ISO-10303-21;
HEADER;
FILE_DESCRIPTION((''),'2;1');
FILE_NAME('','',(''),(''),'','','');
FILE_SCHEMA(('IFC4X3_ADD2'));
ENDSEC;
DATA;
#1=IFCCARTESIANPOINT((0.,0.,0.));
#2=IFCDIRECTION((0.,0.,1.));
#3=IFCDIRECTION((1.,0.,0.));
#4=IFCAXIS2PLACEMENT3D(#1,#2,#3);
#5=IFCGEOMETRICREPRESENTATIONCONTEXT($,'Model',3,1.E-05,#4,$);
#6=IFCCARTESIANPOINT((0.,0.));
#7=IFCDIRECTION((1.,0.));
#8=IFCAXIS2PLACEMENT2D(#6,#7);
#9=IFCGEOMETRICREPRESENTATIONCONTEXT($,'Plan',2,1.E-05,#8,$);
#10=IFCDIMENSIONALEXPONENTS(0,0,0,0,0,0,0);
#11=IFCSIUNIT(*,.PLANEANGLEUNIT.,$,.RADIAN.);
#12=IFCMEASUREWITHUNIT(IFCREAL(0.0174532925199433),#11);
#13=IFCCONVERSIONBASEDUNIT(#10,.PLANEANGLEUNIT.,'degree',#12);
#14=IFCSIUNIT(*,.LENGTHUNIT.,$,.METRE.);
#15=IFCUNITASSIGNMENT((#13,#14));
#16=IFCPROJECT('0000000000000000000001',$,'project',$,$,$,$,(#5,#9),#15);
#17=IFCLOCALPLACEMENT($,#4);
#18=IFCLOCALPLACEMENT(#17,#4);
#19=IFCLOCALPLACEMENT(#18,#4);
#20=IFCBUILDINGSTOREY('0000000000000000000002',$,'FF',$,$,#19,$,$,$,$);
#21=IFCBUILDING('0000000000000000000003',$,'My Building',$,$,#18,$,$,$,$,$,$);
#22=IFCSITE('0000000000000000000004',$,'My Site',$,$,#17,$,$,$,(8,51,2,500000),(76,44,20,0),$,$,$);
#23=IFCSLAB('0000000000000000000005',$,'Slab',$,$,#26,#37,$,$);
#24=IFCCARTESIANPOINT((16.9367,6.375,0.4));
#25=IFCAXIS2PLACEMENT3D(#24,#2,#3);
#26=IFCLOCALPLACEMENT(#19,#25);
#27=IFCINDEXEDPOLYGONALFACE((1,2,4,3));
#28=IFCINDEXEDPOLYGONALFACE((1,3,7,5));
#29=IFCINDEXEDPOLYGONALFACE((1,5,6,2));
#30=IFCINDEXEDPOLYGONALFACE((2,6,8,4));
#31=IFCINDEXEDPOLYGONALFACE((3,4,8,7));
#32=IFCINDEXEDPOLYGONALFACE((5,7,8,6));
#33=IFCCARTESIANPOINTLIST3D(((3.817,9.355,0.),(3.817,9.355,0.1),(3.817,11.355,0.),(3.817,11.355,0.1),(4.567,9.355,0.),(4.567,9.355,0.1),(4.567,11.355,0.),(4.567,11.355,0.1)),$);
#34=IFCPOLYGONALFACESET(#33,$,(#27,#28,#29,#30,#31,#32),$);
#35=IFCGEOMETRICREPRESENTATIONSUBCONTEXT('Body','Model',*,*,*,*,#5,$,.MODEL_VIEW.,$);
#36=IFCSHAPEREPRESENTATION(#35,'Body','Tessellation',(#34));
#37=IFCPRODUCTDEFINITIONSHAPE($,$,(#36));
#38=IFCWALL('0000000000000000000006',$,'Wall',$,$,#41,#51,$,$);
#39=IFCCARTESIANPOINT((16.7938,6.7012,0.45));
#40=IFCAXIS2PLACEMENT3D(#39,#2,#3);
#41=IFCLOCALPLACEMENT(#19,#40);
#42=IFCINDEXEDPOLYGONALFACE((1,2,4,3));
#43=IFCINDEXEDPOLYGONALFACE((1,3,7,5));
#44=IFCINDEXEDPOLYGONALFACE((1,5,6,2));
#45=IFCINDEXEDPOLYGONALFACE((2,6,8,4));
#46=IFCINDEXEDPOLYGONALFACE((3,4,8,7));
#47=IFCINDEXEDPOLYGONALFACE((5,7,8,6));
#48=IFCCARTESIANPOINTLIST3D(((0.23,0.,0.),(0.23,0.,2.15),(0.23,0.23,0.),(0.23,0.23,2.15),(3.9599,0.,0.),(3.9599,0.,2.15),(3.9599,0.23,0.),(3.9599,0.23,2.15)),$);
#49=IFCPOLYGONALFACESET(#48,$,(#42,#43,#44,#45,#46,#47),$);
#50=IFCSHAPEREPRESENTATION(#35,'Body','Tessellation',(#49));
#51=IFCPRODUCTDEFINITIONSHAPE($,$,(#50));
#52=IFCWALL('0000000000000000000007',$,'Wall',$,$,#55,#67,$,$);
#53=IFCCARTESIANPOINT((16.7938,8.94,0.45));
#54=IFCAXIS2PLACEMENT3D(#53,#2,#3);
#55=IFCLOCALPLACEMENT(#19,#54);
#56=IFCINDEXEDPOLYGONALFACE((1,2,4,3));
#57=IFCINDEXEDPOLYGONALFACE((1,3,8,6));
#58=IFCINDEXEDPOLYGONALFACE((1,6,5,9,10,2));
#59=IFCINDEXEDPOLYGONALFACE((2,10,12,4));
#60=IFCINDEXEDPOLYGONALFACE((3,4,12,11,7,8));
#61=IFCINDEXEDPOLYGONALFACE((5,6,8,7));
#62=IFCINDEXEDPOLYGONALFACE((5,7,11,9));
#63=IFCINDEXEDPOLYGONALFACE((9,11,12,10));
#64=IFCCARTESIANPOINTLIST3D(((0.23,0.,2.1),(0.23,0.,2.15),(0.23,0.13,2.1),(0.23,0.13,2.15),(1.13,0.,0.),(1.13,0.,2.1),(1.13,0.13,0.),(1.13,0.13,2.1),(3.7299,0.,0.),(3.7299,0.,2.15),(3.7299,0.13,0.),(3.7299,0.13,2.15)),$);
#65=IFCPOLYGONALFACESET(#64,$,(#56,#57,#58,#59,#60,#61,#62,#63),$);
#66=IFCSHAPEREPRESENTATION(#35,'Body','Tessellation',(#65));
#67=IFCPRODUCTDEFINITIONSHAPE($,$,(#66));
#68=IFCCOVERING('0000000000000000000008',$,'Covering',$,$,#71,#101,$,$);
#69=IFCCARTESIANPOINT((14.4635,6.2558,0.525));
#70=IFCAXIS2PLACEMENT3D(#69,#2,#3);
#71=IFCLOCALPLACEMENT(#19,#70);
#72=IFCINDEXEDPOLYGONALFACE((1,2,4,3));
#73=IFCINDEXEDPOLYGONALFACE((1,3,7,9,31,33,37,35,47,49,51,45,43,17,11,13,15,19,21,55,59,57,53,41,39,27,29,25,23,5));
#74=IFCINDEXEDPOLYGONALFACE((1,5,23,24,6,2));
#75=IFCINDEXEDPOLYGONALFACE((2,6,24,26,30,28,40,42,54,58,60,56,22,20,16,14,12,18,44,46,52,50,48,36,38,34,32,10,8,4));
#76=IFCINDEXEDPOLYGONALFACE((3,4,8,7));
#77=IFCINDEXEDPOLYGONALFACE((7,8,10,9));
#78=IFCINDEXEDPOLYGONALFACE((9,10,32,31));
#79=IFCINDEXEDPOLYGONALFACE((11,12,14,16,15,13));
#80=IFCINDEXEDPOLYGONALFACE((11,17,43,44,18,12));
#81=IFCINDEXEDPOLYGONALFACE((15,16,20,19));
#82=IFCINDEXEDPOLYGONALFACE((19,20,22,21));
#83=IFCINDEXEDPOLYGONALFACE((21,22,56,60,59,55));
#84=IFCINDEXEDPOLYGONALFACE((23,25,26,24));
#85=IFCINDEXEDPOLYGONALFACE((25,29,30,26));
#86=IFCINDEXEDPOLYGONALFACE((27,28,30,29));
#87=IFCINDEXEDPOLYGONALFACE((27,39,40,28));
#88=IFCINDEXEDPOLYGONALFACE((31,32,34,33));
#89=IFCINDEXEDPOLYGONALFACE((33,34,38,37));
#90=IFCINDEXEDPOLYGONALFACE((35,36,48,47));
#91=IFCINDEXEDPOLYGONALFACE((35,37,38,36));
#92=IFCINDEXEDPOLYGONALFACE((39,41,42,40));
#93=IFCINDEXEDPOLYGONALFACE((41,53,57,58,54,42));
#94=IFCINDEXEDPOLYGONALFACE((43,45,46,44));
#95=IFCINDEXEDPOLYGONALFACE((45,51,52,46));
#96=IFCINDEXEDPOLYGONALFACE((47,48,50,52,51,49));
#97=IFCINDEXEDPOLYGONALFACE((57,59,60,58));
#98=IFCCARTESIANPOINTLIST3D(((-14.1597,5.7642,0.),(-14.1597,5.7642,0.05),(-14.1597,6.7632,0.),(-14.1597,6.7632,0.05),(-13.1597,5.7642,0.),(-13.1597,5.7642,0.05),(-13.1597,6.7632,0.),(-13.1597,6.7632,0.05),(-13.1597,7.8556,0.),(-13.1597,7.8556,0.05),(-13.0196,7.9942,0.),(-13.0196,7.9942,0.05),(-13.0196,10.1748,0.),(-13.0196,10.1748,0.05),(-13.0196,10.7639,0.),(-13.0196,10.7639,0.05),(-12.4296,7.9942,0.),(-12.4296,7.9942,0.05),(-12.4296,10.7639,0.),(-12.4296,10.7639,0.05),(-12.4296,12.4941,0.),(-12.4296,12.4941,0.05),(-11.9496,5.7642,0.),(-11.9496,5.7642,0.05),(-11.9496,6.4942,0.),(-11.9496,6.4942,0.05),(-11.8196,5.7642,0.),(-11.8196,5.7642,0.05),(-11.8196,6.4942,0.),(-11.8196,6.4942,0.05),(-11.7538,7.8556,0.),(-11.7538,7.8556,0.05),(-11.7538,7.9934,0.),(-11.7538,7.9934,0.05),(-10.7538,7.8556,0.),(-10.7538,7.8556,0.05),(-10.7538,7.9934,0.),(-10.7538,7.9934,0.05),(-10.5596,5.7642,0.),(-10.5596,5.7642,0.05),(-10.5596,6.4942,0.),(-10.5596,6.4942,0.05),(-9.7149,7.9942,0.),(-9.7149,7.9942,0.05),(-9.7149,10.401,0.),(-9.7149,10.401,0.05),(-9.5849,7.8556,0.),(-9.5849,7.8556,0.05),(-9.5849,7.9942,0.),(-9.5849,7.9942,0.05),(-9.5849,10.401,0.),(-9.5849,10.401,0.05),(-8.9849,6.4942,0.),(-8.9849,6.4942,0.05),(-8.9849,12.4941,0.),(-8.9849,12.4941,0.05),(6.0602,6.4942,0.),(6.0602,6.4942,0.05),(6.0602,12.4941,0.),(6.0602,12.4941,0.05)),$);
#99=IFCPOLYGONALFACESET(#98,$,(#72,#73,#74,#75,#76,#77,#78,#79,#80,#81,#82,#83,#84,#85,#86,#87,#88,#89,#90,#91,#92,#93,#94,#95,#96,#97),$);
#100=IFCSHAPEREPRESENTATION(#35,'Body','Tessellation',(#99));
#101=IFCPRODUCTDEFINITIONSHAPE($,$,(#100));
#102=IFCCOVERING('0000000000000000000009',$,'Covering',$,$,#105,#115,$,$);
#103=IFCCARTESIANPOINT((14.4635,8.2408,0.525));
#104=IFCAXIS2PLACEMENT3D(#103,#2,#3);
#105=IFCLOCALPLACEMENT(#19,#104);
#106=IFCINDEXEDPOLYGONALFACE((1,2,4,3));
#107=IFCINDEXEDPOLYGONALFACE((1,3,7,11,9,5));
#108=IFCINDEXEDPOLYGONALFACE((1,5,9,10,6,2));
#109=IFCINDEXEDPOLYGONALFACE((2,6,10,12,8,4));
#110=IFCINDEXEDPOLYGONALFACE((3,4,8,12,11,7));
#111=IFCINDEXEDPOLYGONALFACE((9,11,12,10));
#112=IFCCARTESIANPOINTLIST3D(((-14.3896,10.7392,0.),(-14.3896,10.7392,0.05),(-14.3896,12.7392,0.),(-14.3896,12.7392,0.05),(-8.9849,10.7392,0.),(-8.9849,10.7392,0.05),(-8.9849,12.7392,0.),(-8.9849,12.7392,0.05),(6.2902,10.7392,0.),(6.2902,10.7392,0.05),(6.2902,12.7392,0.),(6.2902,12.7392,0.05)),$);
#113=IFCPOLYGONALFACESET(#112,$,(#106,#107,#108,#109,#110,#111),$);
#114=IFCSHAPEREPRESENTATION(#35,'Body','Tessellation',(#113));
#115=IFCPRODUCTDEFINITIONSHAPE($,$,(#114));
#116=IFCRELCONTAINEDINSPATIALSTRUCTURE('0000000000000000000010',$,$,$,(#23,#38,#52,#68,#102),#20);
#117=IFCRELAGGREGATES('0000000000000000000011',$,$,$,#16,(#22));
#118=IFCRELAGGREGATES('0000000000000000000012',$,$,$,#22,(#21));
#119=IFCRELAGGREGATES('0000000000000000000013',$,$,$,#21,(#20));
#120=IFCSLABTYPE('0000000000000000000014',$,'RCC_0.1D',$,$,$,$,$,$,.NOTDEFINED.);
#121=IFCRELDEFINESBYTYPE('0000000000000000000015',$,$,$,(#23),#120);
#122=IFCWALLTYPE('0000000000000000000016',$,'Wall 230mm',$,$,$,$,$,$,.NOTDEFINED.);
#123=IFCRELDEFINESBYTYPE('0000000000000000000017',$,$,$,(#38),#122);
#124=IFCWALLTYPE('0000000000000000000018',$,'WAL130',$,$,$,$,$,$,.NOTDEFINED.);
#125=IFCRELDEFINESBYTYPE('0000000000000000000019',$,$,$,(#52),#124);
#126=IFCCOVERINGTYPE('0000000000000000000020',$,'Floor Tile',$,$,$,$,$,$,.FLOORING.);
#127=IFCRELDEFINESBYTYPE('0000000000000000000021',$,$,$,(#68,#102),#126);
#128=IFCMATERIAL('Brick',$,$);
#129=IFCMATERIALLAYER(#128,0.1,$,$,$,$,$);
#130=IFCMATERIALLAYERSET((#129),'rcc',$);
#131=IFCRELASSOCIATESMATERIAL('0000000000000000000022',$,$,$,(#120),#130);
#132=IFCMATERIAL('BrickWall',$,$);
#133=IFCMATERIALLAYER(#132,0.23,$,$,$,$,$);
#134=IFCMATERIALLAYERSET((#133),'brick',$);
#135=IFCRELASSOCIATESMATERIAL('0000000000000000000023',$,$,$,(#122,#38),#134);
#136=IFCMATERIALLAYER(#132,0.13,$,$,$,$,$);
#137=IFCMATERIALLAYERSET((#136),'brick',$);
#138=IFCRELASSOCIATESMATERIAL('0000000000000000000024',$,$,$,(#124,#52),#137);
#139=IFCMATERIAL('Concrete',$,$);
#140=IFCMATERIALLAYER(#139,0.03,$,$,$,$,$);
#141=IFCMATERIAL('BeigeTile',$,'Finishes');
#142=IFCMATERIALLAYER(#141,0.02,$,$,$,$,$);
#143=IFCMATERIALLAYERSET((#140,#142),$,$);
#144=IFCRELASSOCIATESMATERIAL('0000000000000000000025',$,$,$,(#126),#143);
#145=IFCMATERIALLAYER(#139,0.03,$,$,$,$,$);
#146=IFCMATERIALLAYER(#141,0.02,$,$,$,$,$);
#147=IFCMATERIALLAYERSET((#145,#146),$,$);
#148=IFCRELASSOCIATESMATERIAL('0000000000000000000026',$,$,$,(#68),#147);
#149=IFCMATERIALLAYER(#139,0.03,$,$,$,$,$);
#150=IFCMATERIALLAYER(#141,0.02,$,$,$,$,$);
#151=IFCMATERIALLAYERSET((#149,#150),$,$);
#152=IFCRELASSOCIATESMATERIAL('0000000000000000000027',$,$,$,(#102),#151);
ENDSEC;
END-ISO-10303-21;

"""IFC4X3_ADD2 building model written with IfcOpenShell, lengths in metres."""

from ifc_helpers import new_model, entity, si_unit, converted_unit, frame, origin_with_axes, origin_2d_with_axis, place, context, subcontext, project, spatial, line, indexed_curve, outline, extrude, source, transform, mapped, material, layer, layer_set, layer_usage, type_object, element, save


model = new_model("IFC4X3_ADD2")

# Units and contexts
model_context = context("Model", 3, precision=1e-05, world=origin_with_axes())
plan_context = context("Plan", 2, precision=1e-05, world=origin_2d_with_axis())
body_context = subcontext(model_context, "Body", "Model", "MODEL_VIEW")
ifc_project = project(units=[converted_unit("PLANEANGLEUNIT", "degree", entity("IfcReal", 0.0174532925199433), si_unit("PLANEANGLEUNIT", "RADIAN"), dimensions=[0, 0, 0, 0, 0, 0, 0]), si_unit("LENGTHUNIT", "METRE")], contexts=[model_context, plan_context])

# Site, building, storey
site_placement = place(None, origin_with_axes())
site = spatial("IfcSite", under=ifc_project, at=site_placement, Name="My Site", RefLatitude=(8, 51, 2, 500000), RefLongitude=(76, 44, 20, 0))
building_placement = place(site_placement, origin_with_axes())
building = spatial("IfcBuilding", under=site, at=building_placement, Name="My Building")
storey_placement = place(building_placement, origin_with_axes())
storey = spatial("IfcBuildingStorey", under=building, at=storey_placement, Name="FF")

# Shared definitions
ifc_material_1 = material(Name="Brick")

# Slab
ifc_layer_1 = layer(ifc_material_1, 0.1)
ifc_layer_set_1 = layer_set([ifc_layer_1], Name="rcc")
slab_type = type_object("IfcSlabType", Name="RCC_0.1D", PredefinedType="NOTDEFINED", material=ifc_layer_set_1)
slab_placement = place(storey_placement, frame((16.9367, 6.375, 0.4), z_axis=(0.0, 0.0, 1.0), x_axis=(1.0, 0.0, 0.0)))
element("IfcSlab", 1, at=slab_placement, inside=storey, type_object=slab_type, Name="Slab", context=body_context, shape_type="SweptSolid", body=[
    extrude(outline(indexed_curve([(4.567, 9.355), (3.817, 9.355), (3.817, 11.355), (4.567, 11.355), (4.567, 9.355)])), None, (0.0, 0.0, 1.0), 0.1),
])

# Wall
ifc_material_2 = material(Name="BrickWall")
ifc_layer_2 = layer(ifc_material_2, 0.23)
ifc_layer_set_2 = layer_set([ifc_layer_2], Name="brick")
ifc_layer_usage_1 = layer_usage(ifc_layer_set_2, "AXIS2", "POSITIVE", 0.0)
wall_type_1 = type_object("IfcWallType", Name="Wall 230mm", PredefinedType="NOTDEFINED", material=ifc_layer_set_2)
wall_1_placement = place(storey_placement, frame((16.7938, 6.7012, 0.45), z_axis=(0.0, 0.0, 1.0), x_axis=(1.0, 0.0, 0.0)))
element("IfcWall", 2, at=wall_1_placement, inside=storey, type_object=wall_type_1, material=ifc_layer_usage_1, Name="Wall", context=body_context, shape_type="SweptSolid", body=[
    extrude(outline(indexed_curve([(0.23, 0.0), (0.23, 0.23), (3.9599, 0.23), (3.9599, 0.0)], segments=[line(1, 2, 3, 4, 1)])), origin_with_axes(), (0.0, 0.0, 1.0), 2.15),
])

# Wall, opening
ifc_layer_3 = layer(ifc_material_2, 0.13)
ifc_layer_set_3 = layer_set([ifc_layer_3], Name="brick")
ifc_layer_usage_2 = layer_usage(ifc_layer_set_3, "AXIS2", "POSITIVE", 0.0)
wall_type_2 = type_object("IfcWallType", Name="WAL130", PredefinedType="NOTDEFINED", material=ifc_layer_set_3)
wall_2_placement = place(storey_placement, frame((16.7938, 8.94, 0.45), z_axis=(0.0, 0.0, 1.0), x_axis=(1.0, 0.0, 0.0)))
wall_2 = element("IfcWall", 3, at=wall_2_placement, inside=storey, type_object=wall_type_2, material=ifc_layer_usage_2, Name="Wall", context=body_context, shape_type="SweptSolid", body=[
    extrude(outline(indexed_curve([(0.23, 0.0), (0.23, 0.13), (3.7299, 0.13), (3.7299, 0.0)], segments=[line(1, 2, 3, 4, 1)])), origin_with_axes(), (0.0, 0.0, 1.0), 2.15),
])
shared_shape_1 = source(origin_with_axes(), body_context, "Body", "SweptSolid", [
    extrude(outline(indexed_curve([(0.0, 2.1), (0.9, 2.1), (0.9, 0.0), (0.0, 0.0), (0.0, 2.1)])), frame((0.0, -0.6, 0.0), z_axis=(0.0, -1.0, 0.0), x_axis=(1.0, 0.0, 0.0)), (0.0, 0.0, -1.0), 1.2),
])
opening_1_placement = place(wall_2_placement, frame((1.13, 0.1097, 0.0), z_axis=(0.0, 0.0, 1.0), x_axis=(-1.0, 0.0, 0.0)))
element("IfcOpeningElement", 4, at=opening_1_placement, cuts=wall_2, PredefinedType="OPENING", context=body_context, shape_type="MappedRepresentation", body=[
    mapped(shared_shape_1, transform((0.0, 0.0, 0.0), x_axis=(1.0, 0.0, 0.0), y_axis=(0.0, 1.0, 0.0), z_axis=(0.0, 0.0, 1.0), scale=1.0)),
])

# Coverings
ifc_material_3 = material(Name="Concrete")
ifc_layer_4 = layer(ifc_material_3, 0.03)
ifc_material_4 = material(Name="BeigeTile", Category="Finishes")
ifc_layer_5 = layer(ifc_material_4, 0.02)
ifc_layer_set_4 = layer_set([ifc_layer_4, ifc_layer_5])
ifc_layer_usage_3 = layer_usage(ifc_layer_set_4, "AXIS3", "POSITIVE", 0.0)
ifc_layer_6 = layer(ifc_material_3, 0.03)
ifc_layer_7 = layer(ifc_material_4, 0.02)
ifc_layer_set_5 = layer_set([ifc_layer_6, ifc_layer_7])
covering_type_1 = type_object("IfcCoveringType", Name="Floor Tile", PredefinedType="FLOORING", material=ifc_layer_set_5)
covering_1_placement = place(storey_placement, frame((14.4635, 6.2558, 0.525), z_axis=(0.0, 0.0, 1.0), x_axis=(1.0, 0.0, 0.0)))
element("IfcCovering", 5, at=covering_1_placement, inside=storey, type_object=covering_type_1, material=ifc_layer_usage_3, Name="Covering", context=body_context, shape_type="SweptSolid", body=[
    extrude(outline(indexed_curve([(-10.7538, 7.8556), (-9.5849, 7.8556), (-9.5849, 7.9942), (-9.5849, 10.401), (-9.7149, 10.401), (-9.7149, 7.9942), (-12.4296, 7.9942), (-13.0196, 7.9942), (-13.0196, 10.1748), (-13.0196, 10.7639), (-12.4296, 10.7639), (-12.4296, 12.4941), (-8.9849, 12.4941), (6.0602, 12.4941), (6.0602, 6.4942), (-8.9849, 6.4942), (-10.5596, 6.4942), (-10.5596, 5.7642), (-11.8196, 5.7642), (-11.8196, 6.4942), (-11.9496, 6.4942), (-11.9496, 5.7642), (-13.1597, 5.7642), (-14.1597, 5.7642), (-14.1597, 6.7632), (-13.1597, 6.7632), (-13.1597, 7.8556), (-11.7538, 7.8556), (-11.7538, 7.9934), (-10.7538, 7.9934), (-10.7538, 7.8556)])), origin_with_axes(), (0.0, 0.0, 1.0), 0.05),
])
ifc_layer_8 = layer(ifc_material_3, 0.03)
ifc_layer_9 = layer(ifc_material_4, 0.02)
ifc_layer_set_6 = layer_set([ifc_layer_8, ifc_layer_9])
ifc_layer_usage_4 = layer_usage(ifc_layer_set_6, "AXIS3", "POSITIVE", 0.0)
covering_2_placement = place(storey_placement, frame((14.4635, 8.2408, 0.525), z_axis=(0.0, 0.0, 1.0), x_axis=(1.0, 0.0, 0.0)))
element("IfcCovering", 6, at=covering_2_placement, inside=storey, type_object=covering_type_1, material=ifc_layer_usage_4, Name="Covering", context=body_context, shape_type="SweptSolid", body=[
    extrude(outline(indexed_curve([(-8.9849, 10.7392), (-14.3896, 10.7392), (-14.3896, 12.7392), (-8.9849, 12.7392), (6.2902, 12.7392), (6.2902, 10.7392), (-8.9849, 10.7392)])), origin_with_axes(), (0.0, 0.0, 1.0), 0.05),
])

save(model, "model.ifc")
